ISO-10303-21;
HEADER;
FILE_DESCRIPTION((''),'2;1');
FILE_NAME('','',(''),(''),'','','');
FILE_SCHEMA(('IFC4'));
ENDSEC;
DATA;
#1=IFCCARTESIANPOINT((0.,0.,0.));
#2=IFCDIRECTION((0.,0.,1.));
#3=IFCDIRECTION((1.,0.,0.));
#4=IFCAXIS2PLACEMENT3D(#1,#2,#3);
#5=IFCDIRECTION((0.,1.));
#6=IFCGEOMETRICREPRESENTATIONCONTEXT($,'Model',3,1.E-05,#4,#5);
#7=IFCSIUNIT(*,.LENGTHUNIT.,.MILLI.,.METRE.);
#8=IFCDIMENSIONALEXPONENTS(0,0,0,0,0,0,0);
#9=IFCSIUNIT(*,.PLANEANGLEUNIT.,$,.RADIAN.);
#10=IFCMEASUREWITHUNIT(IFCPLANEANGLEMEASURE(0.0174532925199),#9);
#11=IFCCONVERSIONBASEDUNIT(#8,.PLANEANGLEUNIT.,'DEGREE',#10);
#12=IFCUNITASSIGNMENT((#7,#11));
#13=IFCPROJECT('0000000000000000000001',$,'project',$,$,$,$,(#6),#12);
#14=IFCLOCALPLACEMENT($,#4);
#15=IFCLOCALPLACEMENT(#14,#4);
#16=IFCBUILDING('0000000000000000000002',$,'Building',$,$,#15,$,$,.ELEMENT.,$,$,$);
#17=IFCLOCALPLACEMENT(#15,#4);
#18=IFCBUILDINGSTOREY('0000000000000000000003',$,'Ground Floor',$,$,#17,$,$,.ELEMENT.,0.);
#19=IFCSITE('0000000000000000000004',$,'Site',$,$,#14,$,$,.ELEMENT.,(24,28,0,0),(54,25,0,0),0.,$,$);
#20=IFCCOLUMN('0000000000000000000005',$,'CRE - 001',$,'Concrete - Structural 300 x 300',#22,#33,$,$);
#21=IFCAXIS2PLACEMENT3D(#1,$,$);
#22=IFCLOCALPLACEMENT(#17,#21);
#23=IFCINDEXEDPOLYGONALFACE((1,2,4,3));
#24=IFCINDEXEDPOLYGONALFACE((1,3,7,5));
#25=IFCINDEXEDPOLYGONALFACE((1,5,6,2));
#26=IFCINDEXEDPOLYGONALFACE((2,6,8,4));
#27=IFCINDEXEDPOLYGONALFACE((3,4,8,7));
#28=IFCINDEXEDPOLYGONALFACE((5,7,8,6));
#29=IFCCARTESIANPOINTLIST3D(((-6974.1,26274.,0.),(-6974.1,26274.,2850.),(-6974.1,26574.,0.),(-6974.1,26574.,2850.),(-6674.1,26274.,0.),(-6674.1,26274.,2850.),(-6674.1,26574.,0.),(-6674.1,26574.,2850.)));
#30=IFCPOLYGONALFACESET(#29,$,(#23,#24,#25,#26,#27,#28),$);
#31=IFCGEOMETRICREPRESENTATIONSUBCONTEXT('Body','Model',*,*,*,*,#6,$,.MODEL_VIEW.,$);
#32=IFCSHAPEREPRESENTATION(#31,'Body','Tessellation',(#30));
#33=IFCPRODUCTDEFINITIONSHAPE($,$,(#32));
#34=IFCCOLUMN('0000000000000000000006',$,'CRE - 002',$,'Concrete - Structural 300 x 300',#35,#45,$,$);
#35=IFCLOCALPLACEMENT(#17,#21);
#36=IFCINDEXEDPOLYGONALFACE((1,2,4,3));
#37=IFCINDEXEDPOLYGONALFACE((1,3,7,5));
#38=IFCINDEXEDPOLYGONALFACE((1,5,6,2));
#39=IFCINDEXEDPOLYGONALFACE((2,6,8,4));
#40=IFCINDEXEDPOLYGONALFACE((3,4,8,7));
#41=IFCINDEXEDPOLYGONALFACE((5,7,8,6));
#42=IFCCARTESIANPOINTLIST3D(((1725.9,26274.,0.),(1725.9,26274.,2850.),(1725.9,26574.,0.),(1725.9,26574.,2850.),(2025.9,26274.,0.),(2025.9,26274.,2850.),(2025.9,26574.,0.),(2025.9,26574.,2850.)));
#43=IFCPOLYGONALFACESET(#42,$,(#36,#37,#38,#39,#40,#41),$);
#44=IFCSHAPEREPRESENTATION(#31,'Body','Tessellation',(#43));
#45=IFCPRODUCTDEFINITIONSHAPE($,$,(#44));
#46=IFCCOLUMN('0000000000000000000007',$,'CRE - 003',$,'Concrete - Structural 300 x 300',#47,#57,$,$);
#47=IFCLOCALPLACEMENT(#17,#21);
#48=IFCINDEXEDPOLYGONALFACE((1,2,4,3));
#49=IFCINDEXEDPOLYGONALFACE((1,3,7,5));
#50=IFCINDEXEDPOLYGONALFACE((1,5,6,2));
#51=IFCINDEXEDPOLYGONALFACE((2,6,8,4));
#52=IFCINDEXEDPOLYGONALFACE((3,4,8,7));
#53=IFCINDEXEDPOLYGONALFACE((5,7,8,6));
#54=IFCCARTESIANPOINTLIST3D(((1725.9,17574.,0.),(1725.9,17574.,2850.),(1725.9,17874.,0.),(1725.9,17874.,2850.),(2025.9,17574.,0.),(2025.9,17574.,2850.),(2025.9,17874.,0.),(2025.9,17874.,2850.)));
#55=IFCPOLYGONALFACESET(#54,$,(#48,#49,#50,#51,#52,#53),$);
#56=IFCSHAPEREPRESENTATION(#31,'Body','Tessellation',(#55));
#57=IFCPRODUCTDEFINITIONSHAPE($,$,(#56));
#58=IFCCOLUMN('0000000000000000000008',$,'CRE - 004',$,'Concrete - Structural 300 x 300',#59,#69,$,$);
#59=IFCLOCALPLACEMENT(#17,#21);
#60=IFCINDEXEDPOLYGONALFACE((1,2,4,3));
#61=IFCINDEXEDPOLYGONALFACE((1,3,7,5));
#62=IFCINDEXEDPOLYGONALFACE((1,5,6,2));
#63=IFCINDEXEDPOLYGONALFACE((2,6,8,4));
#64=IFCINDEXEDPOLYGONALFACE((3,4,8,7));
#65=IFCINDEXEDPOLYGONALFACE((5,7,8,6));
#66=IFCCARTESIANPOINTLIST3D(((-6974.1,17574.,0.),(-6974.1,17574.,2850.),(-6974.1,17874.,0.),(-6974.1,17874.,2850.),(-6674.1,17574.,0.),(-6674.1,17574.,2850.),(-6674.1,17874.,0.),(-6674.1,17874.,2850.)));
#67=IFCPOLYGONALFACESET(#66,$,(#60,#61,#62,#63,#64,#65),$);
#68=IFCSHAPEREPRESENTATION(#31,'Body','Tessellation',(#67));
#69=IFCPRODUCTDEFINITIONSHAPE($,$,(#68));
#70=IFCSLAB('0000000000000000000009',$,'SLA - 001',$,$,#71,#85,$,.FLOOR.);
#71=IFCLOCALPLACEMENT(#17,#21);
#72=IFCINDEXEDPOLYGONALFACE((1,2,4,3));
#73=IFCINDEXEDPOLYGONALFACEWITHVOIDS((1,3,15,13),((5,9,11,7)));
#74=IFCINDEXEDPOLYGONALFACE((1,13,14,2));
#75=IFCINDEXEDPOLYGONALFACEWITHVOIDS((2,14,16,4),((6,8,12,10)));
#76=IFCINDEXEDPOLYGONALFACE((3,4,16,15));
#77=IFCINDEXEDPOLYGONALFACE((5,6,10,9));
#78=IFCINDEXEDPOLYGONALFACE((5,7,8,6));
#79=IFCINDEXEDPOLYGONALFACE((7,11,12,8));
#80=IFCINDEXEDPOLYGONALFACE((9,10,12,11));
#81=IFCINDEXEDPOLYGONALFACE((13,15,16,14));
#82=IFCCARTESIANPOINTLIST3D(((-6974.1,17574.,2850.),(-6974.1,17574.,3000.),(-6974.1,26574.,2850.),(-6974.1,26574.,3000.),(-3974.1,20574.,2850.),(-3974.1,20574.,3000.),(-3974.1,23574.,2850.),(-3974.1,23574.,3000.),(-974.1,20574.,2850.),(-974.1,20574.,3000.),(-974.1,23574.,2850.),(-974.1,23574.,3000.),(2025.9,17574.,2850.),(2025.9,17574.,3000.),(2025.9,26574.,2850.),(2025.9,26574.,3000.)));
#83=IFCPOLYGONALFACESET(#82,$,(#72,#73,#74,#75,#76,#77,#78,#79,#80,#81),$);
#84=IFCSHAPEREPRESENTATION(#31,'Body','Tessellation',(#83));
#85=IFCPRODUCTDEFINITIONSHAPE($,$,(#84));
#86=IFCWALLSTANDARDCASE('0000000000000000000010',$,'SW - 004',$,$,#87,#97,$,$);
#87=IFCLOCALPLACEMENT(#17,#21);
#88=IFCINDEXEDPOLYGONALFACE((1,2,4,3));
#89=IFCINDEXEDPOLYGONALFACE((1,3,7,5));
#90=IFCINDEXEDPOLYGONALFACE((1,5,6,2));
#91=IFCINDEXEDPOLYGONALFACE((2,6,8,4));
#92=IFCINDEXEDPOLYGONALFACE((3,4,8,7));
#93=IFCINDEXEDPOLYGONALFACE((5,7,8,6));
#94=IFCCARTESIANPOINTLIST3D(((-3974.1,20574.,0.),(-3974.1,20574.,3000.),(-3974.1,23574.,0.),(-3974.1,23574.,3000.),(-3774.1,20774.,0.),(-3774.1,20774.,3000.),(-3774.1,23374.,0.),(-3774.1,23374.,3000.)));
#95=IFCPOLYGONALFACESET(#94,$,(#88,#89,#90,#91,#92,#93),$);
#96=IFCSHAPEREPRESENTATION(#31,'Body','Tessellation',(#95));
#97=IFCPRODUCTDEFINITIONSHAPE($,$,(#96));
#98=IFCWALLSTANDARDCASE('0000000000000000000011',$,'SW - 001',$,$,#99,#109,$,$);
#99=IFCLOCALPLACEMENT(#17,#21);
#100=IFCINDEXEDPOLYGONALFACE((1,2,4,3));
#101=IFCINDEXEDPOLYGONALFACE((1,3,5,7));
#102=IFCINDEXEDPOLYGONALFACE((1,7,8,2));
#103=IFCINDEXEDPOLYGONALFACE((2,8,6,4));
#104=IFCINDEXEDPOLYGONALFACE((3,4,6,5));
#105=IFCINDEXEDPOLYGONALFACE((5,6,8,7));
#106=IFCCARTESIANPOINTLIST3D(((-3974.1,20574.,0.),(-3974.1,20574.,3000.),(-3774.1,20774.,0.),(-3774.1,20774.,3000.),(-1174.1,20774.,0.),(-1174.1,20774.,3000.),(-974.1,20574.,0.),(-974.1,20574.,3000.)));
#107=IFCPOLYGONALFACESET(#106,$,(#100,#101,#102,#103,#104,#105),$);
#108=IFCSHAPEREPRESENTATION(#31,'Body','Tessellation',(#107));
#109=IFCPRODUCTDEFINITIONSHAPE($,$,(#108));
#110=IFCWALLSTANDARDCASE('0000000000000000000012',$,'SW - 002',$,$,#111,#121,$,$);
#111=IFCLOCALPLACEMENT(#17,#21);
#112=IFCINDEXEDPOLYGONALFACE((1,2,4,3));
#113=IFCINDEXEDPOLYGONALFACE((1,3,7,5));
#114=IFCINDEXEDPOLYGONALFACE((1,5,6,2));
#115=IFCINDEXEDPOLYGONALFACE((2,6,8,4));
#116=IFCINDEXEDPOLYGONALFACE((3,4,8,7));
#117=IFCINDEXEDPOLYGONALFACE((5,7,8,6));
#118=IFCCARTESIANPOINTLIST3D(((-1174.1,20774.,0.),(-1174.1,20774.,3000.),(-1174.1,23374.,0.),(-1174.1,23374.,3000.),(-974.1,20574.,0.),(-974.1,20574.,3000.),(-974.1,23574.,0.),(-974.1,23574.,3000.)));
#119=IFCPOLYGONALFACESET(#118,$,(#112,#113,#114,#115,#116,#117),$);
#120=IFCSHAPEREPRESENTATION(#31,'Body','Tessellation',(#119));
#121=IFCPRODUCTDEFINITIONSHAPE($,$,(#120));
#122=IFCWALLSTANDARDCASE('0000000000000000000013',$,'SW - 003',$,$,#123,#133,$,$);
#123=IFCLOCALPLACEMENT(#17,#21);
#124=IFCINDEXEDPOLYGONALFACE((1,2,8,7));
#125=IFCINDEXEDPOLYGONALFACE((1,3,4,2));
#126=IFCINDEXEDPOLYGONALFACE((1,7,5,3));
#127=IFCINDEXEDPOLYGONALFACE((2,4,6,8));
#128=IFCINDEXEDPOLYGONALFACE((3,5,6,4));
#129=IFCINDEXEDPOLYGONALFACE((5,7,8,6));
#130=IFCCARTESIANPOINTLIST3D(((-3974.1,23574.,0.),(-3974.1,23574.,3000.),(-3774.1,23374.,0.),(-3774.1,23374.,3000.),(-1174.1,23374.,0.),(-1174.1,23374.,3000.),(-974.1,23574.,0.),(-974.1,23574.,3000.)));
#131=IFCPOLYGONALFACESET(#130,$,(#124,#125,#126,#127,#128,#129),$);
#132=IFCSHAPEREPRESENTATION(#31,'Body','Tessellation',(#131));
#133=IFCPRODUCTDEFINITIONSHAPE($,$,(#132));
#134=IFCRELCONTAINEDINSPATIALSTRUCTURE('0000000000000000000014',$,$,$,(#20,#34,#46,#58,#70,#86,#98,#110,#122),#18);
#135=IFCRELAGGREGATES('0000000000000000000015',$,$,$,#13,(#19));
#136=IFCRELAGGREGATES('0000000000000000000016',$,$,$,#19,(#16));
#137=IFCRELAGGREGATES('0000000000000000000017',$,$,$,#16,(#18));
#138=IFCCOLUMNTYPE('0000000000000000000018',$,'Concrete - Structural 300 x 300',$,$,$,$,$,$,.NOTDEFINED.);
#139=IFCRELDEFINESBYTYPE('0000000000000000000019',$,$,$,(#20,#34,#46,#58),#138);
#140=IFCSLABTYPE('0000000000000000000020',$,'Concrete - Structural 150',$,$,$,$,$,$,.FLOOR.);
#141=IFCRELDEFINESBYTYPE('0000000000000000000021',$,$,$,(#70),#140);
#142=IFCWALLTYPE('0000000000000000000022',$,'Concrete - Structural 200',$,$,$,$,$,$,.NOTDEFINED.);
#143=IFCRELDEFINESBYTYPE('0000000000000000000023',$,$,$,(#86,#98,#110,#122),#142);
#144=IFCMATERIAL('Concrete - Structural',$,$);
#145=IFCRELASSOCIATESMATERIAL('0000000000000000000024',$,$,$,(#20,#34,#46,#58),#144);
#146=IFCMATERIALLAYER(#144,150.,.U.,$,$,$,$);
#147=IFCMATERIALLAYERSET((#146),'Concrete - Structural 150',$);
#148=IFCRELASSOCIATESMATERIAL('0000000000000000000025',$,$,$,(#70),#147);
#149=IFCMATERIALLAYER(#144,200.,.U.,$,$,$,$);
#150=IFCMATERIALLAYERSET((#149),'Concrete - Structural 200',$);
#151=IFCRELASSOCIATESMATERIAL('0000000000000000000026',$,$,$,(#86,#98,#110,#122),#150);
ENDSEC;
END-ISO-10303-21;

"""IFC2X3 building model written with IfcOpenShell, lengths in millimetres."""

from ifc_helpers import new_model, entity, si_unit, converted_unit, direction, frame, origin_with_axes, origin_2d_with_axis, place, context, subcontext, project, spatial, polyline, rectangle, outline, extrude, material, layer, layer_set, layer_usage, type_object, element, save


model = new_model("IFC2X3")

# Units and contexts
model_context = context("Model", 3, precision=1e-05, world=origin_with_axes(), true_north=direction((0.0, 1.0)))
body_context = subcontext(model_context, "Body", "Model", "MODEL_VIEW")
ifc_project = project(units=[si_unit("LENGTHUNIT", "METRE", prefix="MILLI"), converted_unit("PLANEANGLEUNIT", "DEGREE", entity("IfcPlaneAngleMeasure", 0.0174532925199), si_unit("PLANEANGLEUNIT", "RADIAN"), dimensions=[0, 0, 0, 0, 0, 0, 0])], contexts=[model_context])

# Site, building, storey
site_placement = place(None, origin_with_axes())
site = spatial("IfcSite", under=ifc_project, at=site_placement, Name="Site", CompositionType="ELEMENT", RefLatitude=(24, 28, 0, 0), RefLongitude=(54, 25, 0, 0), RefElevation=0.0)
building_placement = place(site_placement, origin_with_axes())
building = spatial("IfcBuilding", under=site, at=building_placement, Name="Building", CompositionType="ELEMENT")
storey_placement = place(building_placement, origin_with_axes())
storey = spatial("IfcBuildingStorey", under=building, at=storey_placement, Name="Ground Floor", CompositionType="ELEMENT", Elevation=0.0)

# Columns
ifc_material = material(Name="Concrete - Structural")
column_type = type_object("IfcColumnType", Name="Concrete - Structural 300 x 300", PredefinedType="NOTDEFINED")
for number, where, z_axis, x_axis, name in (
    (1, (-6824.1, 26424.0, 0.0), (0.0, 0.0, 1.0), (1.0, 0.0, 0.0), "CRE - 001"),
    (2, (1875.9, 26424.0, 0.0), (0.0, 0.0, 1.0), (1.0, 0.0, 0.0), "CRE - 002"),
    (3, (1875.9, 17724.0, 0.0), (0.0, 0.0, 1.0), (1.0, 0.0, 0.0), "CRE - 003"),
    (4, (-6824.1, 17724.0, 0.0), (0.0, 0.0, 1.0), (1.0, 0.0, 0.0), "CRE - 004"),
):
    element("IfcColumn", number, at=place(storey_placement, frame(where, z_axis=z_axis, x_axis=x_axis)), inside=storey, type_object=column_type, material=ifc_material, Name=name, ObjectType="Concrete - Structural 300 x 300", context=body_context, shape_type="SweptSolid", body=[
        extrude(rectangle(XDim=300.0, YDim=300.0, at=origin_2d_with_axis()), origin_with_axes(), (0.0, 0.0, 1.0), 2850.0),
    ])

# Slab, opening
ifc_layer_1 = layer(ifc_material, 150.0, ventilated="UNKNOWN")
ifc_layer_set_1 = layer_set([ifc_layer_1], Name="Concrete - Structural 150")
ifc_layer_usage_1 = layer_usage(ifc_layer_set_1, "AXIS3", "NEGATIVE", 150.0)
slab_type = type_object("IfcSlabType", Name="Concrete - Structural 150", PredefinedType="FLOOR")
slab_placement = place(storey_placement, frame((-6974.1, 26574.0, 3000.0), z_axis=(0.0, 0.0, 1.0), x_axis=(1.0, 0.0, 0.0)))
slab = element("IfcSlab", 5, at=slab_placement, inside=storey, type_object=slab_type, material=ifc_layer_usage_1, Name="SLA - 001", PredefinedType="FLOOR", context=body_context, shape_type="SweptSolid", body=[
    extrude(outline(polyline([(0.0, 0.0), (0.0, -9000.0), (9000.0, -9000.0), (9000.0, 0.0), (0.0, 0.0)])), frame((0.0, 0.0, -150.0), z_axis=(0.0, 0.0, 1.0), x_axis=(1.0, 0.0, 0.0)), (0.0, 0.0, 1.0), 150.0),
])
opening_placement = place(slab_placement, origin_with_axes())
element("IfcOpeningElement", 6, at=opening_placement, cuts=slab, context=body_context, shape_type="SweptSolid", body=[
    extrude(outline(polyline([(3000.0, -3000.0), (3000.0, -6000.0), (6000.0, -6000.0), (6000.0, -3000.0), (3000.0, -3000.0)])), frame((0.0, 0.0, -150.0), z_axis=(0.0, 0.0, 1.0), x_axis=(1.0, 0.0, 0.0)), (0.0, 0.0, 1.0), 150.0),
])

# Walls
ifc_layer_2 = layer(ifc_material, 200.0, ventilated="UNKNOWN")
ifc_layer_set_2 = layer_set([ifc_layer_2], Name="Concrete - Structural 200")
ifc_layer_usage_2 = layer_usage(ifc_layer_set_2, "AXIS2", "POSITIVE", 0.0)
wall_type = type_object("IfcWallType", Name="Concrete - Structural 200", PredefinedType="NOTDEFINED")
wall_1_placement = place(storey_placement, frame((-3974.1, 23574.0, 0.0), z_axis=(0.0, 0.0, 1.0), x_axis=(0.0, -1.0, 0.0)))
element("IfcWallStandardCase", 7, at=wall_1_placement, inside=storey, type_object=wall_type, material=ifc_layer_usage_2, Name="SW - 004", context=body_context, shape_type="SweptSolid", body=[
    extrude(outline(polyline([(0.0, 0.0), (3000.0, 0.0), (2800.0, 200.0), (200.0, 200.0), (0.0, 0.0)])), origin_with_axes(), (0.0, 0.0, 1.0), 3000.0),
])
ifc_layer_usage_3 = layer_usage(ifc_layer_set_2, "AXIS2", "POSITIVE", 0.0)
wall_2_placement = place(storey_placement, frame((-3974.1, 20574.0, 0.0), z_axis=(0.0, 0.0, 1.0), x_axis=(1.0, 0.0, 0.0)))
element("IfcWallStandardCase", 8, at=wall_2_placement, inside=storey, type_object=wall_type, material=ifc_layer_usage_3, Name="SW - 001", context=body_context, shape_type="SweptSolid", body=[
    extrude(outline(polyline([(0.0, 0.0), (3000.0, 0.0), (2800.0, 200.0), (200.0, 200.0), (0.0, 0.0)])), origin_with_axes(), (0.0, 0.0, 1.0), 3000.0),
])
ifc_layer_usage_4 = layer_usage(ifc_layer_set_2, "AXIS2", "POSITIVE", 0.0)
wall_3_placement = place(storey_placement, frame((-974.1, 20574.0, 0.0), z_axis=(0.0, 0.0, 1.0), x_axis=(0.0, 1.0, 0.0)))
element("IfcWallStandardCase", 9, at=wall_3_placement, inside=storey, type_object=wall_type, material=ifc_layer_usage_4, Name="SW - 002", context=body_context, shape_type="SweptSolid", body=[
    extrude(outline(polyline([(0.0, 0.0), (3000.0, 0.0), (2800.0, 200.0), (200.0, 200.0), (0.0, 0.0)])), origin_with_axes(), (0.0, 0.0, 1.0), 3000.0),
])
ifc_layer_usage_5 = layer_usage(ifc_layer_set_2, "AXIS2", "POSITIVE", 0.0)
wall_4_placement = place(storey_placement, frame((-974.1, 23574.0, 0.0), z_axis=(0.0, 0.0, 1.0), x_axis=(-1.0, 0.0, 0.0)))
element("IfcWallStandardCase", 10, at=wall_4_placement, inside=storey, type_object=wall_type, material=ifc_layer_usage_5, Name="SW - 003", context=body_context, shape_type="SweptSolid", body=[
    extrude(outline(polyline([(0.0, 0.0), (3000.0, 0.0), (2800.0, 200.0), (200.0, 200.0), (0.0, 0.0)])), origin_with_axes(), (0.0, 0.0, 1.0), 3000.0),
])

save(model, "model.ifc")
